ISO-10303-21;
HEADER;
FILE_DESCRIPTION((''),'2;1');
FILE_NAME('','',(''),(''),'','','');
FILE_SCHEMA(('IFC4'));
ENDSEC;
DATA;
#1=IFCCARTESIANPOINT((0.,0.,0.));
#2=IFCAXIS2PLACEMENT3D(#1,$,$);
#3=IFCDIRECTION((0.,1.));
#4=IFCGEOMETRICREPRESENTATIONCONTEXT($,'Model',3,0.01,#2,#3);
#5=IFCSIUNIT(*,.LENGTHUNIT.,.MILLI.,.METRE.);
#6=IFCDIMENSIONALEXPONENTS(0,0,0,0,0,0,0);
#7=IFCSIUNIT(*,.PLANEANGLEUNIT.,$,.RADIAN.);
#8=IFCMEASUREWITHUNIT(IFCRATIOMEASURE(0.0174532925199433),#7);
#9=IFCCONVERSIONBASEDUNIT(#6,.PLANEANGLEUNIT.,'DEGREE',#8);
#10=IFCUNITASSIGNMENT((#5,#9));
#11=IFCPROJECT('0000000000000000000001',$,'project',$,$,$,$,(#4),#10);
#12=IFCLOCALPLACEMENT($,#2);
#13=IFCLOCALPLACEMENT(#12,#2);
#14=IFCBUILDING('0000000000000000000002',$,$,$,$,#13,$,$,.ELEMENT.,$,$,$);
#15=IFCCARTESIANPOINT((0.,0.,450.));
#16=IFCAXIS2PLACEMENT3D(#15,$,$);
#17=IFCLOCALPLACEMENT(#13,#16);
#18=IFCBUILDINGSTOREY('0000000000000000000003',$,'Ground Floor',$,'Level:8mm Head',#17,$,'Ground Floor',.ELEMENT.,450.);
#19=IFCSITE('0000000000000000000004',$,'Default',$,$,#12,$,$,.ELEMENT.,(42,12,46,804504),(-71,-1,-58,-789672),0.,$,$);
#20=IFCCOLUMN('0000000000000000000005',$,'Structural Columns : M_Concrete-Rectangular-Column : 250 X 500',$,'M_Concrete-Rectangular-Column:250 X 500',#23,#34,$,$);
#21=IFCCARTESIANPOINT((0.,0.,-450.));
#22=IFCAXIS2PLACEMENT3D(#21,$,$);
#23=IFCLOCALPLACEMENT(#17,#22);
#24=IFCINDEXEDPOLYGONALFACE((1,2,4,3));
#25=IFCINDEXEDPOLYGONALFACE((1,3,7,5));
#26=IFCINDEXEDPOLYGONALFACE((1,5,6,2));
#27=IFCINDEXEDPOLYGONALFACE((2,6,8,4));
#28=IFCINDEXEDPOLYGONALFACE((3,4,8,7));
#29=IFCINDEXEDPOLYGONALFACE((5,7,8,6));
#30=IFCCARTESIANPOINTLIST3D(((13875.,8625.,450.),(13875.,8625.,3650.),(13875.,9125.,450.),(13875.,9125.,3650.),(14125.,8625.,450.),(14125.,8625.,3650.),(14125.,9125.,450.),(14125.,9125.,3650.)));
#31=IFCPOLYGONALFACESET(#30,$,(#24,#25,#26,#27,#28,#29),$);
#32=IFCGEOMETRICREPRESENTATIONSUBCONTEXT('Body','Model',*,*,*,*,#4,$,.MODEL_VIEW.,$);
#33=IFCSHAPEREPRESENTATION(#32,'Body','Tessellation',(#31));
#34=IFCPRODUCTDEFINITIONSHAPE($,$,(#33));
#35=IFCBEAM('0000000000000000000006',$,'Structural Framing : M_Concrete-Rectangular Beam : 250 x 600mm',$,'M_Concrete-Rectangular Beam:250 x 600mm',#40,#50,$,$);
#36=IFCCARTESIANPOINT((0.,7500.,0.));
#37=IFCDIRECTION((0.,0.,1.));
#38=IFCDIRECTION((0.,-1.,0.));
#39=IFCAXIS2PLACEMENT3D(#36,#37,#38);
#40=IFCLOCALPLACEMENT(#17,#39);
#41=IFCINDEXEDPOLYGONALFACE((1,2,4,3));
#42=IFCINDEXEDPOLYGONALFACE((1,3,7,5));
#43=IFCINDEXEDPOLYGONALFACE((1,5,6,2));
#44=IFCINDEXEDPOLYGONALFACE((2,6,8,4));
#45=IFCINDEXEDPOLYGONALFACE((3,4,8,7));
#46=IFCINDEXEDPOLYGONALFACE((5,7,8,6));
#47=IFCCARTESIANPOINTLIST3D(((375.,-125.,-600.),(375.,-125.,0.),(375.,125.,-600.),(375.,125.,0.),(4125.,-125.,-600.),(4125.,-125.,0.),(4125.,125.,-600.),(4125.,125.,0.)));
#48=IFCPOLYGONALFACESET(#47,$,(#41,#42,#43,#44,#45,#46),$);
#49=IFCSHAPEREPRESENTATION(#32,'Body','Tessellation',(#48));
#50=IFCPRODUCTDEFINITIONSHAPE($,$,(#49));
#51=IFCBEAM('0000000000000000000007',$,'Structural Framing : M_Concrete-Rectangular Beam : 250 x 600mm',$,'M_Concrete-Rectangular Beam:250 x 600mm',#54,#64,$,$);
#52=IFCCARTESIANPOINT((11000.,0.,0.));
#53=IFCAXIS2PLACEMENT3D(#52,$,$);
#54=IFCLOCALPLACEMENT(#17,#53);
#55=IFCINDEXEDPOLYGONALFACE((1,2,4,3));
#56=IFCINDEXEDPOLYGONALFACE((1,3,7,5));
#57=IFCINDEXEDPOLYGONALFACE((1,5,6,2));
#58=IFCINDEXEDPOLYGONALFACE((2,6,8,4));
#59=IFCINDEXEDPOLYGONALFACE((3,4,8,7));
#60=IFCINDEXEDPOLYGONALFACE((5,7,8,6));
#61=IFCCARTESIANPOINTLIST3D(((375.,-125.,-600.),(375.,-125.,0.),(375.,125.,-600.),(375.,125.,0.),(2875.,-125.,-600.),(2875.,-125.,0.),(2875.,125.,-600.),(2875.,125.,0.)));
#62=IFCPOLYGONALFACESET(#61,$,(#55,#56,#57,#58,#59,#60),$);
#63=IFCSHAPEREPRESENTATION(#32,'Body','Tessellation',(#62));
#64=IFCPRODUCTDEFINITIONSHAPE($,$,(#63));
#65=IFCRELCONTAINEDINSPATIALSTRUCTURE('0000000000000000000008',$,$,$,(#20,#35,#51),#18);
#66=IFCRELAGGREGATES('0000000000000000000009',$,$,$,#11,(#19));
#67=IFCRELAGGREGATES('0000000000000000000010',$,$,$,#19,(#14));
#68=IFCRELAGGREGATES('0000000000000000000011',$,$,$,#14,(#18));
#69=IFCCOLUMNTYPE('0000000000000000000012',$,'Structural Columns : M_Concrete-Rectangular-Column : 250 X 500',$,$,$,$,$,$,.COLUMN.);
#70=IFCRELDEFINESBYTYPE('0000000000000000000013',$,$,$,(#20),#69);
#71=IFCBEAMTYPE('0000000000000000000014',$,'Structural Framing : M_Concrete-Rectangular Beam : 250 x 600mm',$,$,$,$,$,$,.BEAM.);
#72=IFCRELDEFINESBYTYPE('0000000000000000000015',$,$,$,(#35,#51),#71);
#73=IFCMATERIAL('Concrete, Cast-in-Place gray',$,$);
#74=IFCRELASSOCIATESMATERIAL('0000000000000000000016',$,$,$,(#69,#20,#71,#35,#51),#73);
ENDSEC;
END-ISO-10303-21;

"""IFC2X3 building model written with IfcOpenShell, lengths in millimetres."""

from ifc_helpers import new_model, entity, si_unit, converted_unit, direction, frame, frame_2d, origin, origin_2d_with_axis, place, context, subcontext, project, spatial, rectangle, extrude, source, transform, mapped, material, type_object, type_shapes, element, save


model = new_model("IFC2X3")

# Units and contexts
model_context = context("Model", 3, precision=0.01, world=origin(), true_north=direction((0.0, 1.0)))
body_context = subcontext(model_context, "Body", "Model", "MODEL_VIEW")
ifc_project = project(units=[si_unit("LENGTHUNIT", "METRE", prefix="MILLI"), converted_unit("PLANEANGLEUNIT", "DEGREE", entity("IfcRatioMeasure", 0.0174532925199433), si_unit("PLANEANGLEUNIT", "RADIAN"), dimensions=[0, 0, 0, 0, 0, 0, 0])], contexts=[model_context])

# Site, building, storey
site_placement = place(None, origin())
site = spatial("IfcSite", under=ifc_project, at=site_placement, Name="Default", CompositionType="ELEMENT", RefLatitude=(42, 12, 46, 804504), RefLongitude=(-71, -1, -58, -789672), RefElevation=0.0)
building_placement = place(site_placement, origin())
building = spatial("IfcBuilding", under=site, at=building_placement, CompositionType="ELEMENT")
storey_placement = place(building_placement, frame((0.0, 0.0, 450.0)))
storey = spatial("IfcBuildingStorey", under=building, at=storey_placement, Name="Ground Floor", ObjectType="Level:8mm Head", LongName="Ground Floor", CompositionType="ELEMENT", Elevation=450.0)

# Column
ifc_material = material(Name="Concrete, Cast-in-Place gray")
column_type_1 = type_object("IfcColumnType", Name="Structural Columns : M_Concrete-Rectangular-Column : 250 X 500", PredefinedType="COLUMN", material=ifc_material)
shared_shape_1 = source(origin(), body_context, "Body", "SweptSolid", [
    extrude(rectangle(XDim=500.0, YDim=250.0, at=frame_2d((0.0, 0.0), x_axis=(1.0, 0.0))), frame((14000.0, 8875.0, 450.0), z_axis=(0.0, 0.0, 1.0), x_axis=(0.0, -1.0, 0.0)), (0.0, 0.0, 1.0), 3200.0),
])
type_shapes(column_type_1, [shared_shape_1])
column_1_placement = place(storey_placement, frame((0.0, 0.0, -450.0)))
element("IfcColumn", 1, at=column_1_placement, inside=storey, type_object=column_type_1, material=ifc_material, Name="Structural Columns : M_Concrete-Rectangular-Column : 250 X 500", ObjectType="M_Concrete-Rectangular-Column:250 X 500", context=body_context, shape_type="MappedRepresentation", body=[
    mapped(shared_shape_1, transform((0.0, 0.0, 0.0), scale=1.0)),
])

# Beams
beam_type_1 = type_object("IfcBeamType", Name="Structural Framing : M_Concrete-Rectangular Beam : 250 x 600mm", PredefinedType="BEAM", material=ifc_material)
beam_1_placement = place(storey_placement, frame((0.0, 7500.0, 0.0), z_axis=(0.0, 0.0, 1.0), x_axis=(0.0, -1.0, 0.0)))
element("IfcBeam", 2, at=beam_1_placement, inside=storey, type_object=beam_type_1, material=ifc_material, Name="Structural Framing : M_Concrete-Rectangular Beam : 250 x 600mm", ObjectType="M_Concrete-Rectangular Beam:250 x 600mm", context=body_context, shape_type="SweptSolid", body=[
    extrude(rectangle(XDim=600.0, YDim=250.0, at=origin_2d_with_axis()), frame((375.0, 0.0, -300.0), z_axis=(1.0, 0.0, 0.0), x_axis=(0.0, 0.0, -1.0)), (0.0, 0.0, 1.0), 3750.0),
])
beam_2_placement = place(storey_placement, frame((11000.0, 0.0, 0.0)))
element("IfcBeam", 3, at=beam_2_placement, inside=storey, type_object=beam_type_1, material=ifc_material, Name="Structural Framing : M_Concrete-Rectangular Beam : 250 x 600mm", ObjectType="M_Concrete-Rectangular Beam:250 x 600mm", context=body_context, shape_type="SweptSolid", body=[
    extrude(rectangle(XDim=600.0, YDim=250.0, at=frame_2d((0.0, 0.0), x_axis=(1.0, 0.0))), frame((375.0, 0.0, -300.0), z_axis=(1.0, 0.0, 0.0), x_axis=(0.0, 0.0, -1.0)), (0.0, 0.0, 1.0), 2500.0),
])

save(model, "model.ifc")
